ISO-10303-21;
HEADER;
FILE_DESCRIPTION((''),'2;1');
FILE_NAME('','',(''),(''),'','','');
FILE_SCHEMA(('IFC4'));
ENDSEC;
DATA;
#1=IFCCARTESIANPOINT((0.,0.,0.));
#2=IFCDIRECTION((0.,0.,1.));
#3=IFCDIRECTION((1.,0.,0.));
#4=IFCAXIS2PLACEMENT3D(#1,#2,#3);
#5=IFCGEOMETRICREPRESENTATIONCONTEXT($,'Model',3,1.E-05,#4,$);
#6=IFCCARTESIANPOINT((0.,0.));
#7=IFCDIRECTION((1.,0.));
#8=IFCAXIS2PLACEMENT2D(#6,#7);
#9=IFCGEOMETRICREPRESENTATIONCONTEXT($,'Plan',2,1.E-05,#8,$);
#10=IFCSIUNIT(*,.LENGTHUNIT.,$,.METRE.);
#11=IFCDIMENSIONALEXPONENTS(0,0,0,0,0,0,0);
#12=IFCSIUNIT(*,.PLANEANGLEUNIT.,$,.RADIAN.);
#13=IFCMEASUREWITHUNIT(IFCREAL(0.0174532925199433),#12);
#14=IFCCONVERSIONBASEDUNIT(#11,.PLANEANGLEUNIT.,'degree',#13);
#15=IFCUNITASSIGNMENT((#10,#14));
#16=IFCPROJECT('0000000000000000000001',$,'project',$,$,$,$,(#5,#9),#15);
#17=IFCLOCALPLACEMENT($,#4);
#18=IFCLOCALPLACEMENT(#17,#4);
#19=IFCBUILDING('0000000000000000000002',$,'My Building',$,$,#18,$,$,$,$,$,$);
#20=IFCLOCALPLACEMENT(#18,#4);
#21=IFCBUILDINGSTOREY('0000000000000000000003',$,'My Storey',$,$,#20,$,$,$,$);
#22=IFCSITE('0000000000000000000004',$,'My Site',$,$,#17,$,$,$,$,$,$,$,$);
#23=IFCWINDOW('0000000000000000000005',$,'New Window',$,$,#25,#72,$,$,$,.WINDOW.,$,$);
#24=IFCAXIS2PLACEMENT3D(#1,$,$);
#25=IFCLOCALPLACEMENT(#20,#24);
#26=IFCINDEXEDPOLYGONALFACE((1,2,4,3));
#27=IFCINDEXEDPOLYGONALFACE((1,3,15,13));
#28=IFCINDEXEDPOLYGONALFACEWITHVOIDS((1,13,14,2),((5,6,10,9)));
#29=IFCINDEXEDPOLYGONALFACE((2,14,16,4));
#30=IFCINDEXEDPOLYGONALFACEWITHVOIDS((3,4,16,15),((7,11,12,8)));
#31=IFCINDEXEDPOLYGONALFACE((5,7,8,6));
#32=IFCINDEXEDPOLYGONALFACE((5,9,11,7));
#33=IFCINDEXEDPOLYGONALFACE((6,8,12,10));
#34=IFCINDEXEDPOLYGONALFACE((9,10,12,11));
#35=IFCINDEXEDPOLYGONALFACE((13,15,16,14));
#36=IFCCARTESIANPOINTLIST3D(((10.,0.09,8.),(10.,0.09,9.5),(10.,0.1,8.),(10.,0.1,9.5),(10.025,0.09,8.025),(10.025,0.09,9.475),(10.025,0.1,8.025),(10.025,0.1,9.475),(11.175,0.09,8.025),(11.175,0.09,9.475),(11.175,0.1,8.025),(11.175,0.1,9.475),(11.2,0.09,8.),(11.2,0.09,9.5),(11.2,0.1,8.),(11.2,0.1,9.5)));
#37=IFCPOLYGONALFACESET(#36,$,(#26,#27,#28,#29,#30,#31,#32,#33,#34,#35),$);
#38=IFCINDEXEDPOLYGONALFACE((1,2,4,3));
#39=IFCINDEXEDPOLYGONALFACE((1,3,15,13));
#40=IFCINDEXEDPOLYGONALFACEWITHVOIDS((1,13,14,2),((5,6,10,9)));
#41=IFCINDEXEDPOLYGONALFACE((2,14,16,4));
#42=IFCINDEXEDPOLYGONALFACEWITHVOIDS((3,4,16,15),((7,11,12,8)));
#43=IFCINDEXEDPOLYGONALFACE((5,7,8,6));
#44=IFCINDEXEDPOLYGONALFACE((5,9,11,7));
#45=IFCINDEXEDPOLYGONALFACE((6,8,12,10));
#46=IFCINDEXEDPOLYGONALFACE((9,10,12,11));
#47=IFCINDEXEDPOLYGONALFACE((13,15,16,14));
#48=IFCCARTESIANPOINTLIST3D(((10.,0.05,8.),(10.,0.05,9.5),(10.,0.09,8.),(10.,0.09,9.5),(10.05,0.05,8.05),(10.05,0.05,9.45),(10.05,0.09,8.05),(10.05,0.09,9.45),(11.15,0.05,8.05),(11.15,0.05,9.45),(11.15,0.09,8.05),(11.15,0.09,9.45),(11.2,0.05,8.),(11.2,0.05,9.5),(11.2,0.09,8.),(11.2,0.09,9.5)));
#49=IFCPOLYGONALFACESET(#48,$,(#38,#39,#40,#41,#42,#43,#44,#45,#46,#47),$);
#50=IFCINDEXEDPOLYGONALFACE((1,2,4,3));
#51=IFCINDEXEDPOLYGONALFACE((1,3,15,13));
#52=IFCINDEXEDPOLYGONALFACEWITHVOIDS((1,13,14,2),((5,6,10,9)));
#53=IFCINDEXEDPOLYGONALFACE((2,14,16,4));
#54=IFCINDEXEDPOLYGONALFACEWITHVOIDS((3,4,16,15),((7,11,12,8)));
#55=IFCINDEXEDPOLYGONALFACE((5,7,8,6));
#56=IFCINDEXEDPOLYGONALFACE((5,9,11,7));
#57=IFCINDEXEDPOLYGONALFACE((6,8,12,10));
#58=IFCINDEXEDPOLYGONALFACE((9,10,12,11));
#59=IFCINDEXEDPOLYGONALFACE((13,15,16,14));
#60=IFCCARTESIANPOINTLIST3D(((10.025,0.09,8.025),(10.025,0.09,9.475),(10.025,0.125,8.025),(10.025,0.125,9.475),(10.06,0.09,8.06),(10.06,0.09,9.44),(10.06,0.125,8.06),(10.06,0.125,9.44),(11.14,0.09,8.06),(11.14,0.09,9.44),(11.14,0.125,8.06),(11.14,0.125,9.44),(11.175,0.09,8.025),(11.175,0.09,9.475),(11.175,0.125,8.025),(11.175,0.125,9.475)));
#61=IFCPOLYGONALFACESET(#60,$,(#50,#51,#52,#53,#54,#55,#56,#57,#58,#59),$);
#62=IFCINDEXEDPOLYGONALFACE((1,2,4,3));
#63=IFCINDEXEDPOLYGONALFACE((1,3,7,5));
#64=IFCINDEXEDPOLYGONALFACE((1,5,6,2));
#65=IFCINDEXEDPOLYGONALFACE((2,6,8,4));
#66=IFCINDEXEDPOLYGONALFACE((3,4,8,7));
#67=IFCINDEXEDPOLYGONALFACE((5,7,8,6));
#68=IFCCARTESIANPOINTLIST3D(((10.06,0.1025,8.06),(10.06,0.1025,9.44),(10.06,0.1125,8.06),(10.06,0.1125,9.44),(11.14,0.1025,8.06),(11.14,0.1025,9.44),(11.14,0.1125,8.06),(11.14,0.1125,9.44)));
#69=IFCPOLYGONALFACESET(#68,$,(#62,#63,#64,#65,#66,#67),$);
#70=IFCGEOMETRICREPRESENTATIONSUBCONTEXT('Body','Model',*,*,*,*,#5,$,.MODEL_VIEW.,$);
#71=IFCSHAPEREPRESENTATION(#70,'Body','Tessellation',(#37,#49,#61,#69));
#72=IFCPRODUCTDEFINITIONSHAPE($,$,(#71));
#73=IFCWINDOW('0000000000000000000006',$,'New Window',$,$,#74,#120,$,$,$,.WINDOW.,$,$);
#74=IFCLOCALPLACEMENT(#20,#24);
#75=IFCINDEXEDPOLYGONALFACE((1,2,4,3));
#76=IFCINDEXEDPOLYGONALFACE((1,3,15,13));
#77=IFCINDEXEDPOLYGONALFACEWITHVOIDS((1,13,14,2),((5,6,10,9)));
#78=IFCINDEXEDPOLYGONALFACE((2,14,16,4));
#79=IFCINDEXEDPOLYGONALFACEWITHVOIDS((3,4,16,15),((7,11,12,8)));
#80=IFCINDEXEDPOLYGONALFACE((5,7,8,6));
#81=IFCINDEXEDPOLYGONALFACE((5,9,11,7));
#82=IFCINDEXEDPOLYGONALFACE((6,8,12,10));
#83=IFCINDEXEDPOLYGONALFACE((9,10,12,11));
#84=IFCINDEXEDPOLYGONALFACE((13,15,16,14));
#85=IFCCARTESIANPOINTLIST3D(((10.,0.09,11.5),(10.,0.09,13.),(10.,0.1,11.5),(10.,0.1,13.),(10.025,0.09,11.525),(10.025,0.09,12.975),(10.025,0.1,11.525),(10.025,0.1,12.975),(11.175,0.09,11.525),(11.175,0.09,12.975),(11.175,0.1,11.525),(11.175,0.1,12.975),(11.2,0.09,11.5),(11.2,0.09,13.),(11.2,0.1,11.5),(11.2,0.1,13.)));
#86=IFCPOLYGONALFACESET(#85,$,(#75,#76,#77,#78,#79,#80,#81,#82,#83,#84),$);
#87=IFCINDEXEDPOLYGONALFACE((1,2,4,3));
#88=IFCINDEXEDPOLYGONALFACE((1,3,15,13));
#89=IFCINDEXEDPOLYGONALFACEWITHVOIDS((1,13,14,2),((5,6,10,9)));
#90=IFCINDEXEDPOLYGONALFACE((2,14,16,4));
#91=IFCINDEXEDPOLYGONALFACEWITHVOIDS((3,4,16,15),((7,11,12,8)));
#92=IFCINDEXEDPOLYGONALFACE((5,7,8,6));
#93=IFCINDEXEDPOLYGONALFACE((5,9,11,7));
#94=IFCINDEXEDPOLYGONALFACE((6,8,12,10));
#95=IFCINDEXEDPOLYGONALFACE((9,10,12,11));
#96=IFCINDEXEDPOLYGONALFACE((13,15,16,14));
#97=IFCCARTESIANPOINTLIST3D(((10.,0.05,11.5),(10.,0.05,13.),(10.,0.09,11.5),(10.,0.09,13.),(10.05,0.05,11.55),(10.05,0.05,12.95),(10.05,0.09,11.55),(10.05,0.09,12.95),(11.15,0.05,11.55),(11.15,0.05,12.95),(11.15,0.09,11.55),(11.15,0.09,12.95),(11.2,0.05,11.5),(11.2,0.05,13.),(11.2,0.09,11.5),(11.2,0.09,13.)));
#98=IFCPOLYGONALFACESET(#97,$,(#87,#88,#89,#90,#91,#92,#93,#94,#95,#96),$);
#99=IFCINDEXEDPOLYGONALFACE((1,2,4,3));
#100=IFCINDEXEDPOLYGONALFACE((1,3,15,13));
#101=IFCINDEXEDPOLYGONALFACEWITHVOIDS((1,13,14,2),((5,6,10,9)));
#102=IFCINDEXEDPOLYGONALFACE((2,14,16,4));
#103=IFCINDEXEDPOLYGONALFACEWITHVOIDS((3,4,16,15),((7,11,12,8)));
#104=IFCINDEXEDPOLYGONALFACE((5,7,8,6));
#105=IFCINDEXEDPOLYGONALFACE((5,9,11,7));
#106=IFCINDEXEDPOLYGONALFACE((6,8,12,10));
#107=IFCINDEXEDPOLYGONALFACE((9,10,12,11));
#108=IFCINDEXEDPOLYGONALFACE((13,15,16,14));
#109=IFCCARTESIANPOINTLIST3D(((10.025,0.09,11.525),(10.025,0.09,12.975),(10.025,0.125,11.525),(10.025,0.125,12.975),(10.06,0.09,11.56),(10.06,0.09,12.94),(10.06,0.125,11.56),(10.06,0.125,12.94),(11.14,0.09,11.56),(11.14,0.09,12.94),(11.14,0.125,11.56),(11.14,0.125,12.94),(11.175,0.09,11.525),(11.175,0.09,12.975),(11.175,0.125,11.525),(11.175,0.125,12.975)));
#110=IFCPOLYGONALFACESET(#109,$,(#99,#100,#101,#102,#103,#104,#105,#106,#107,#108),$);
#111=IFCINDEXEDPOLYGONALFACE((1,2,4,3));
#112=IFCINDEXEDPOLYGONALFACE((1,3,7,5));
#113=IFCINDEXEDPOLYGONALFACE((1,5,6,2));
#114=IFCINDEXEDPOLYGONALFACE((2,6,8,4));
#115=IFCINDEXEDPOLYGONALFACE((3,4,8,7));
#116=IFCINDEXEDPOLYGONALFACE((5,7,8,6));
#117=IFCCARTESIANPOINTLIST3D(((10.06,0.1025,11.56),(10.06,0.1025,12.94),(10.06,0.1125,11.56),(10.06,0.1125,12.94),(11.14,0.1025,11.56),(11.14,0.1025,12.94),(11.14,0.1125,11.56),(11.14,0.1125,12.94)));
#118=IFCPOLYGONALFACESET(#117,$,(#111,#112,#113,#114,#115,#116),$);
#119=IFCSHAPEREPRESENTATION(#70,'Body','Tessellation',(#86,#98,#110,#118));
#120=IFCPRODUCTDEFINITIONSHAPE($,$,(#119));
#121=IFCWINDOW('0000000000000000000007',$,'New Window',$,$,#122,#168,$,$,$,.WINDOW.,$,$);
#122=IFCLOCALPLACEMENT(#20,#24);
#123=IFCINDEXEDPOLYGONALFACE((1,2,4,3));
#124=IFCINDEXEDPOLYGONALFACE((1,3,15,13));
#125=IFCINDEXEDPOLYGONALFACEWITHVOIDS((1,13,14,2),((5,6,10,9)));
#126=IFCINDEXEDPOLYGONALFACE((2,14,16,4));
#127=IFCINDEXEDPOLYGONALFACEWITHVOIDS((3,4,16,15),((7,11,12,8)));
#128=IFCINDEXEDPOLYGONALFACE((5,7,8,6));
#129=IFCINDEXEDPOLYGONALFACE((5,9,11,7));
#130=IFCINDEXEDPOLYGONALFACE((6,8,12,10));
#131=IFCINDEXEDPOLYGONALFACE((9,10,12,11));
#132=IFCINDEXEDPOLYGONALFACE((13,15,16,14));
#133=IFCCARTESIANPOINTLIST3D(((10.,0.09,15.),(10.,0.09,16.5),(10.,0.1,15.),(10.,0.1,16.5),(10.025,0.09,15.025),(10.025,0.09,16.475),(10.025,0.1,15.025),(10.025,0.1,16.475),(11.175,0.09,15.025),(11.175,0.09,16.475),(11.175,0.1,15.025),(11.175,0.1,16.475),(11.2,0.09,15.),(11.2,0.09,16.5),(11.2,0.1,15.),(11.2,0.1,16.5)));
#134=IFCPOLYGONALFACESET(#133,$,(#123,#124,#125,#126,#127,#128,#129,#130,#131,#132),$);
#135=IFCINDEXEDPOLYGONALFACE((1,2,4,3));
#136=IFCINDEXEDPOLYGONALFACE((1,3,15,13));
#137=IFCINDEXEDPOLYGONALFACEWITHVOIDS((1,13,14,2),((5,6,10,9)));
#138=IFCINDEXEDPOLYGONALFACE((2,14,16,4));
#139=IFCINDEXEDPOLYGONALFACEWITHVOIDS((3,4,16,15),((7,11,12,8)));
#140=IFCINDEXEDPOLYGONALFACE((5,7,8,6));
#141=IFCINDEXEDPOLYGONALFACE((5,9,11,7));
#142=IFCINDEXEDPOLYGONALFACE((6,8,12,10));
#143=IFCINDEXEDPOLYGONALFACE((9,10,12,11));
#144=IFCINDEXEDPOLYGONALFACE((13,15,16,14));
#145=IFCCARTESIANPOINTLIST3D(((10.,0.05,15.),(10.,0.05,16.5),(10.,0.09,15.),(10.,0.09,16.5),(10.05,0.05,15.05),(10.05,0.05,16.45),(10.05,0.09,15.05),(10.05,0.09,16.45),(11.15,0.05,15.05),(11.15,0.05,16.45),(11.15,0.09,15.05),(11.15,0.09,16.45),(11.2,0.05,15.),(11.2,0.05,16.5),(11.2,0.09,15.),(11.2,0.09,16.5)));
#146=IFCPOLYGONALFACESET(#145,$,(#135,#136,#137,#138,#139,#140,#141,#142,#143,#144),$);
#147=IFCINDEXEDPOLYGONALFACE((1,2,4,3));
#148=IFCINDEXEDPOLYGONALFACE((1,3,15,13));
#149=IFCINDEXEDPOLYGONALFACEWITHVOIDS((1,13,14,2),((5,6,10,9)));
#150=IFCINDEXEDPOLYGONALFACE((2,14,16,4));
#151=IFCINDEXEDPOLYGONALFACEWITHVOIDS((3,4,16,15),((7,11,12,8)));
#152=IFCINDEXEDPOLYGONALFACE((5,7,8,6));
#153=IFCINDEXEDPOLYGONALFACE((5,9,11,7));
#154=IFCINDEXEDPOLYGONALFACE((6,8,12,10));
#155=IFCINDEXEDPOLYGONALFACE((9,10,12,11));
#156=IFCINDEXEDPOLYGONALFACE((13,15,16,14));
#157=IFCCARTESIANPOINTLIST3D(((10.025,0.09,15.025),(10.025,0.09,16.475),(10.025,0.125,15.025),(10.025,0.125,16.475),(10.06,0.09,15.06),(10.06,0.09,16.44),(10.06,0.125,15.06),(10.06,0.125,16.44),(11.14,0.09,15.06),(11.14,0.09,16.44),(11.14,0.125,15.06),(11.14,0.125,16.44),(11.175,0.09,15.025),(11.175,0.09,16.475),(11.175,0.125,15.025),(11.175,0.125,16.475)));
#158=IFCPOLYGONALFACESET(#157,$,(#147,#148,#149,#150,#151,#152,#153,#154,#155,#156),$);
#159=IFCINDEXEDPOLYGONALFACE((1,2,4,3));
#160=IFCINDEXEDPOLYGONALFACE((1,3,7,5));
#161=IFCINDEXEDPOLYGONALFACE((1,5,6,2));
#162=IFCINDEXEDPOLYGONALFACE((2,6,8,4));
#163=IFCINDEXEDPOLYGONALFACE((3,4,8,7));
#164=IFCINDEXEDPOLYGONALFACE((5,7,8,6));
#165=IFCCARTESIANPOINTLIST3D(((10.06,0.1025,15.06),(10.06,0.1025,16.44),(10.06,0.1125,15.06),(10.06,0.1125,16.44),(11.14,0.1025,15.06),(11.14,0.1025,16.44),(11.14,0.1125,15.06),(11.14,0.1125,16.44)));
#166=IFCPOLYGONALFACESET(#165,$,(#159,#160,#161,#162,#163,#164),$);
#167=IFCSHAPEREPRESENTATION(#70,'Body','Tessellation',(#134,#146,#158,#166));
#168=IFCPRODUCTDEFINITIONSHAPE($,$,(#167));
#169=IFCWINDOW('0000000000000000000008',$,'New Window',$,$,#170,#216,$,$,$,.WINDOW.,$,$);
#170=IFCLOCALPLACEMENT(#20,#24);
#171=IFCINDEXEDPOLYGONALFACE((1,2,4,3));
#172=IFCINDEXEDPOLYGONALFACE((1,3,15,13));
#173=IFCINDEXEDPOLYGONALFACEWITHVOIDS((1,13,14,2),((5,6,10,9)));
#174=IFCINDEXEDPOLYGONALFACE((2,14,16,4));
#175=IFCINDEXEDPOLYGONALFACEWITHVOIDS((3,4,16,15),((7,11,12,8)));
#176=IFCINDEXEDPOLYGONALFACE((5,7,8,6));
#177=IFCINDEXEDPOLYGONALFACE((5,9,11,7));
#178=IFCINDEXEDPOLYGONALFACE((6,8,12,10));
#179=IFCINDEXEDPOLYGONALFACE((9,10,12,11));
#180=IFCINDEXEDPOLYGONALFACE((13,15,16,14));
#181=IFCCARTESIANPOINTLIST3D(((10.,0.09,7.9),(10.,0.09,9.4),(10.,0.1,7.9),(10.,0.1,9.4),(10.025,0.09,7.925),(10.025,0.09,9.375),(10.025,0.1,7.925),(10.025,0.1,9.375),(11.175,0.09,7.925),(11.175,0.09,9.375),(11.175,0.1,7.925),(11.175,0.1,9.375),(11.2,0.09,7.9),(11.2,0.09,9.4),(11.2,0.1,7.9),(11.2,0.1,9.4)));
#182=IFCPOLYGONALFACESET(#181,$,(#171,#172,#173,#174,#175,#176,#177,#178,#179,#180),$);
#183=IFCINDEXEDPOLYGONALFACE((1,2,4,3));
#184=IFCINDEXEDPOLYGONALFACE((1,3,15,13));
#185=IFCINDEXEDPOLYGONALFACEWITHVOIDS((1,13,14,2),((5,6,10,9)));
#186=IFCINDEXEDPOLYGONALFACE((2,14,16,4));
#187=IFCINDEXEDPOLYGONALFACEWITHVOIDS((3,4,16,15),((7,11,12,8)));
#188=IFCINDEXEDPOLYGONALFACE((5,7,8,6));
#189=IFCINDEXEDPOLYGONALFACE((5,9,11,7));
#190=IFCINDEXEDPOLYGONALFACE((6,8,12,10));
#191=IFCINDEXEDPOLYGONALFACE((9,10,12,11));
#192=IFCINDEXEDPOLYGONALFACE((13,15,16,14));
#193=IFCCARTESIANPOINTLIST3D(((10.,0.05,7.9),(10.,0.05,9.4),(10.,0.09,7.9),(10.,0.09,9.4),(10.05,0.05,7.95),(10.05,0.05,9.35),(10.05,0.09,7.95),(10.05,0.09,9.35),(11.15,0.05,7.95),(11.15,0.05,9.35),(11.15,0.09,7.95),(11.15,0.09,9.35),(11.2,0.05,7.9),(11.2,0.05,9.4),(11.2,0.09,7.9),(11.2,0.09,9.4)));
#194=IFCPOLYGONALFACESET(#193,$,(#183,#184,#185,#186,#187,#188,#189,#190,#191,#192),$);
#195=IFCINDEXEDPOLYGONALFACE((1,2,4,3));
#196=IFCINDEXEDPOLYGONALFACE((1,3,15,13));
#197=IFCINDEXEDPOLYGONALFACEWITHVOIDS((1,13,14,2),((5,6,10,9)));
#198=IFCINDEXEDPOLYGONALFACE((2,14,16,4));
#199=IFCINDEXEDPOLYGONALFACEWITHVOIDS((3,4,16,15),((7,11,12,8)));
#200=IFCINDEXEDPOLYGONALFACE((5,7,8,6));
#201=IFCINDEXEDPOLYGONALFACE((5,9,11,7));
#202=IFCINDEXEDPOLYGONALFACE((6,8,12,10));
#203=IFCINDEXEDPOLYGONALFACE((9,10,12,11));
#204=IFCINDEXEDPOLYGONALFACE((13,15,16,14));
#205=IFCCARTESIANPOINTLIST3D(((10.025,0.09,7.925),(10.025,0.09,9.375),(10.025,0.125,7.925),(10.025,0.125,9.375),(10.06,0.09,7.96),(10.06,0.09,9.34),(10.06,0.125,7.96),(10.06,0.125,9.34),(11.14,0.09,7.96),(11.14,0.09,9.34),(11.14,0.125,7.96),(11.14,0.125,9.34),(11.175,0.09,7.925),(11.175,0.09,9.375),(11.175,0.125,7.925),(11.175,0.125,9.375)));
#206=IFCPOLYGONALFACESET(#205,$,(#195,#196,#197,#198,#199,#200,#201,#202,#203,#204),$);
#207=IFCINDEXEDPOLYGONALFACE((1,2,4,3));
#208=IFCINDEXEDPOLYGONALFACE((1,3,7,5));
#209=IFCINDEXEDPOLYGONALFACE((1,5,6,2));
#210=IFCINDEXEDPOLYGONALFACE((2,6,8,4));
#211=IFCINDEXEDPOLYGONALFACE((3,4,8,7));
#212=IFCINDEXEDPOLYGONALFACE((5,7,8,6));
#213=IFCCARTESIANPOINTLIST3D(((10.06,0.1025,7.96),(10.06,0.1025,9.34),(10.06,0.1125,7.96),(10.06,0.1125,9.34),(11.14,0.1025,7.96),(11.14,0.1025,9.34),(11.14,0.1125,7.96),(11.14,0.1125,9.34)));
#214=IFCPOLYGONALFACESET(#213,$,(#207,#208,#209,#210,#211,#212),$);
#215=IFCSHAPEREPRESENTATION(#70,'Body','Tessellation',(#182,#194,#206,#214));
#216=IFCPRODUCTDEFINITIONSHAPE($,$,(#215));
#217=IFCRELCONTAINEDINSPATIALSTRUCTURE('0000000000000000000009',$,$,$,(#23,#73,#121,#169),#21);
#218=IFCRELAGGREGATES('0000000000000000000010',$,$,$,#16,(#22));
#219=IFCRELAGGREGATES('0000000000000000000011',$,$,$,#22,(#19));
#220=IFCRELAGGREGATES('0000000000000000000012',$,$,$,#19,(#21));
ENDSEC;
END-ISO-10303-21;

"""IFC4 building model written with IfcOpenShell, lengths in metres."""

from ifc_helpers import new_model, entity, si_unit, converted_unit, frame, origin_with_axes, origin_2d_with_axis, place, context, subcontext, project, spatial, line, indexed_curve, outline, extrude, element, save


model = new_model("IFC4")

# Units and contexts
model_context = context("Model", 3, precision=1e-05, world=origin_with_axes())
plan_context = context("Plan", 2, precision=1e-05, world=origin_2d_with_axis())
body_context = subcontext(model_context, "Body", "Model", "MODEL_VIEW")
ifc_project = project(units=[si_unit("LENGTHUNIT", "METRE"), converted_unit("PLANEANGLEUNIT", "degree", entity("IfcReal", 0.0174532925199433), si_unit("PLANEANGLEUNIT", "RADIAN"), dimensions=[0, 0, 0, 0, 0, 0, 0])], contexts=[model_context, plan_context])

# Site, building, storey
site_placement = place(None, origin_with_axes())
site = spatial("IfcSite", under=ifc_project, at=site_placement, Name="My Site")
building_placement = place(site_placement, origin_with_axes())
building = spatial("IfcBuilding", under=site, at=building_placement, Name="My Building")
storey_placement = place(building_placement, origin_with_axes())
storey = spatial("IfcBuildingStorey", under=building, at=storey_placement, Name="My Storey")

# Windows
for number, where, z_axis, x_axis, name in (
    (1, (10.0, 0.0, 8.0), (0.0, 0.0, 1.0), (1.0, 0.0, 0.0), "New Window"),
    (2, (10.0, 0.0, 11.5), (0.0, 0.0, 1.0), (1.0, 0.0, 0.0), "New Window"),
    (3, (10.0, 0.0, 15.0), (0.0, 0.0, 1.0), (1.0, 0.0, 0.0), "New Window"),
    (4, (10.0, 0.0, 7.9), (0.0, 0.0, 1.0), (1.0, 0.0, 0.0), "New Window"),
):
    element("IfcWindow", number, at=place(storey_placement, frame(where, z_axis=z_axis, x_axis=x_axis)), inside=storey, Name=name, PredefinedType="WINDOW", context=body_context, shape_type="SweptSolid", body=[
        extrude(outline(indexed_curve([(0.0, 0.0), (1.2, 0.0), (1.2, 1.5), (0.0, 1.5)], segments=[line(1, 2, 3, 4, 1)]), holes=[indexed_curve([(0.025, 0.025), (1.175, 0.025), (1.175, 1.475), (0.025, 1.475)], segments=[line(1, 2, 3, 4, 1)])]), frame((0.0, 0.09, 0.0), z_axis=(0.0, -1.0, 0.0), x_axis=(1.0, 0.0, 0.0)), (0.0, 0.0, -1.0), 0.01),
        extrude(outline(indexed_curve([(0.0, 0.0), (1.2, 0.0), (1.2, 1.5), (0.0, 1.5)], segments=[line(1, 2, 3, 4, 1)]), holes=[indexed_curve([(0.05, 0.05), (1.15, 0.05), (1.15, 1.45), (0.05, 1.45)], segments=[line(1, 2, 3, 4, 1)])]), frame((0.0, 0.05, 0.0), z_axis=(0.0, -1.0, 0.0), x_axis=(1.0, 0.0, 0.0)), (0.0, 0.0, -1.0), 0.04),
        extrude(outline(indexed_curve([(0.0, 0.0), (1.15, 0.0), (1.15, 1.45), (0.0, 1.45)], segments=[line(1, 2, 3, 4, 1)]), holes=[indexed_curve([(0.035, 0.035), (1.115, 0.035), (1.115, 1.415), (0.035, 1.415)], segments=[line(1, 2, 3, 4, 1)])]), frame((0.025, 0.09, 0.025), z_axis=(0.0, -1.0, 0.0), x_axis=(1.0, 0.0, 0.0)), (0.0, 0.0, -1.0), 0.035),
        extrude(outline(indexed_curve([(0.035, 0.035), (1.115, 0.035), (1.115, 1.415), (0.035, 1.415)], segments=[line(1, 2, 3, 4, 1)])), frame((0.025, 0.1025, 0.025), z_axis=(0.0, -1.0, 0.0), x_axis=(1.0, 0.0, 0.0)), (0.0, 0.0, -1.0), 0.01),
    ])

save(model, "model.ifc")
